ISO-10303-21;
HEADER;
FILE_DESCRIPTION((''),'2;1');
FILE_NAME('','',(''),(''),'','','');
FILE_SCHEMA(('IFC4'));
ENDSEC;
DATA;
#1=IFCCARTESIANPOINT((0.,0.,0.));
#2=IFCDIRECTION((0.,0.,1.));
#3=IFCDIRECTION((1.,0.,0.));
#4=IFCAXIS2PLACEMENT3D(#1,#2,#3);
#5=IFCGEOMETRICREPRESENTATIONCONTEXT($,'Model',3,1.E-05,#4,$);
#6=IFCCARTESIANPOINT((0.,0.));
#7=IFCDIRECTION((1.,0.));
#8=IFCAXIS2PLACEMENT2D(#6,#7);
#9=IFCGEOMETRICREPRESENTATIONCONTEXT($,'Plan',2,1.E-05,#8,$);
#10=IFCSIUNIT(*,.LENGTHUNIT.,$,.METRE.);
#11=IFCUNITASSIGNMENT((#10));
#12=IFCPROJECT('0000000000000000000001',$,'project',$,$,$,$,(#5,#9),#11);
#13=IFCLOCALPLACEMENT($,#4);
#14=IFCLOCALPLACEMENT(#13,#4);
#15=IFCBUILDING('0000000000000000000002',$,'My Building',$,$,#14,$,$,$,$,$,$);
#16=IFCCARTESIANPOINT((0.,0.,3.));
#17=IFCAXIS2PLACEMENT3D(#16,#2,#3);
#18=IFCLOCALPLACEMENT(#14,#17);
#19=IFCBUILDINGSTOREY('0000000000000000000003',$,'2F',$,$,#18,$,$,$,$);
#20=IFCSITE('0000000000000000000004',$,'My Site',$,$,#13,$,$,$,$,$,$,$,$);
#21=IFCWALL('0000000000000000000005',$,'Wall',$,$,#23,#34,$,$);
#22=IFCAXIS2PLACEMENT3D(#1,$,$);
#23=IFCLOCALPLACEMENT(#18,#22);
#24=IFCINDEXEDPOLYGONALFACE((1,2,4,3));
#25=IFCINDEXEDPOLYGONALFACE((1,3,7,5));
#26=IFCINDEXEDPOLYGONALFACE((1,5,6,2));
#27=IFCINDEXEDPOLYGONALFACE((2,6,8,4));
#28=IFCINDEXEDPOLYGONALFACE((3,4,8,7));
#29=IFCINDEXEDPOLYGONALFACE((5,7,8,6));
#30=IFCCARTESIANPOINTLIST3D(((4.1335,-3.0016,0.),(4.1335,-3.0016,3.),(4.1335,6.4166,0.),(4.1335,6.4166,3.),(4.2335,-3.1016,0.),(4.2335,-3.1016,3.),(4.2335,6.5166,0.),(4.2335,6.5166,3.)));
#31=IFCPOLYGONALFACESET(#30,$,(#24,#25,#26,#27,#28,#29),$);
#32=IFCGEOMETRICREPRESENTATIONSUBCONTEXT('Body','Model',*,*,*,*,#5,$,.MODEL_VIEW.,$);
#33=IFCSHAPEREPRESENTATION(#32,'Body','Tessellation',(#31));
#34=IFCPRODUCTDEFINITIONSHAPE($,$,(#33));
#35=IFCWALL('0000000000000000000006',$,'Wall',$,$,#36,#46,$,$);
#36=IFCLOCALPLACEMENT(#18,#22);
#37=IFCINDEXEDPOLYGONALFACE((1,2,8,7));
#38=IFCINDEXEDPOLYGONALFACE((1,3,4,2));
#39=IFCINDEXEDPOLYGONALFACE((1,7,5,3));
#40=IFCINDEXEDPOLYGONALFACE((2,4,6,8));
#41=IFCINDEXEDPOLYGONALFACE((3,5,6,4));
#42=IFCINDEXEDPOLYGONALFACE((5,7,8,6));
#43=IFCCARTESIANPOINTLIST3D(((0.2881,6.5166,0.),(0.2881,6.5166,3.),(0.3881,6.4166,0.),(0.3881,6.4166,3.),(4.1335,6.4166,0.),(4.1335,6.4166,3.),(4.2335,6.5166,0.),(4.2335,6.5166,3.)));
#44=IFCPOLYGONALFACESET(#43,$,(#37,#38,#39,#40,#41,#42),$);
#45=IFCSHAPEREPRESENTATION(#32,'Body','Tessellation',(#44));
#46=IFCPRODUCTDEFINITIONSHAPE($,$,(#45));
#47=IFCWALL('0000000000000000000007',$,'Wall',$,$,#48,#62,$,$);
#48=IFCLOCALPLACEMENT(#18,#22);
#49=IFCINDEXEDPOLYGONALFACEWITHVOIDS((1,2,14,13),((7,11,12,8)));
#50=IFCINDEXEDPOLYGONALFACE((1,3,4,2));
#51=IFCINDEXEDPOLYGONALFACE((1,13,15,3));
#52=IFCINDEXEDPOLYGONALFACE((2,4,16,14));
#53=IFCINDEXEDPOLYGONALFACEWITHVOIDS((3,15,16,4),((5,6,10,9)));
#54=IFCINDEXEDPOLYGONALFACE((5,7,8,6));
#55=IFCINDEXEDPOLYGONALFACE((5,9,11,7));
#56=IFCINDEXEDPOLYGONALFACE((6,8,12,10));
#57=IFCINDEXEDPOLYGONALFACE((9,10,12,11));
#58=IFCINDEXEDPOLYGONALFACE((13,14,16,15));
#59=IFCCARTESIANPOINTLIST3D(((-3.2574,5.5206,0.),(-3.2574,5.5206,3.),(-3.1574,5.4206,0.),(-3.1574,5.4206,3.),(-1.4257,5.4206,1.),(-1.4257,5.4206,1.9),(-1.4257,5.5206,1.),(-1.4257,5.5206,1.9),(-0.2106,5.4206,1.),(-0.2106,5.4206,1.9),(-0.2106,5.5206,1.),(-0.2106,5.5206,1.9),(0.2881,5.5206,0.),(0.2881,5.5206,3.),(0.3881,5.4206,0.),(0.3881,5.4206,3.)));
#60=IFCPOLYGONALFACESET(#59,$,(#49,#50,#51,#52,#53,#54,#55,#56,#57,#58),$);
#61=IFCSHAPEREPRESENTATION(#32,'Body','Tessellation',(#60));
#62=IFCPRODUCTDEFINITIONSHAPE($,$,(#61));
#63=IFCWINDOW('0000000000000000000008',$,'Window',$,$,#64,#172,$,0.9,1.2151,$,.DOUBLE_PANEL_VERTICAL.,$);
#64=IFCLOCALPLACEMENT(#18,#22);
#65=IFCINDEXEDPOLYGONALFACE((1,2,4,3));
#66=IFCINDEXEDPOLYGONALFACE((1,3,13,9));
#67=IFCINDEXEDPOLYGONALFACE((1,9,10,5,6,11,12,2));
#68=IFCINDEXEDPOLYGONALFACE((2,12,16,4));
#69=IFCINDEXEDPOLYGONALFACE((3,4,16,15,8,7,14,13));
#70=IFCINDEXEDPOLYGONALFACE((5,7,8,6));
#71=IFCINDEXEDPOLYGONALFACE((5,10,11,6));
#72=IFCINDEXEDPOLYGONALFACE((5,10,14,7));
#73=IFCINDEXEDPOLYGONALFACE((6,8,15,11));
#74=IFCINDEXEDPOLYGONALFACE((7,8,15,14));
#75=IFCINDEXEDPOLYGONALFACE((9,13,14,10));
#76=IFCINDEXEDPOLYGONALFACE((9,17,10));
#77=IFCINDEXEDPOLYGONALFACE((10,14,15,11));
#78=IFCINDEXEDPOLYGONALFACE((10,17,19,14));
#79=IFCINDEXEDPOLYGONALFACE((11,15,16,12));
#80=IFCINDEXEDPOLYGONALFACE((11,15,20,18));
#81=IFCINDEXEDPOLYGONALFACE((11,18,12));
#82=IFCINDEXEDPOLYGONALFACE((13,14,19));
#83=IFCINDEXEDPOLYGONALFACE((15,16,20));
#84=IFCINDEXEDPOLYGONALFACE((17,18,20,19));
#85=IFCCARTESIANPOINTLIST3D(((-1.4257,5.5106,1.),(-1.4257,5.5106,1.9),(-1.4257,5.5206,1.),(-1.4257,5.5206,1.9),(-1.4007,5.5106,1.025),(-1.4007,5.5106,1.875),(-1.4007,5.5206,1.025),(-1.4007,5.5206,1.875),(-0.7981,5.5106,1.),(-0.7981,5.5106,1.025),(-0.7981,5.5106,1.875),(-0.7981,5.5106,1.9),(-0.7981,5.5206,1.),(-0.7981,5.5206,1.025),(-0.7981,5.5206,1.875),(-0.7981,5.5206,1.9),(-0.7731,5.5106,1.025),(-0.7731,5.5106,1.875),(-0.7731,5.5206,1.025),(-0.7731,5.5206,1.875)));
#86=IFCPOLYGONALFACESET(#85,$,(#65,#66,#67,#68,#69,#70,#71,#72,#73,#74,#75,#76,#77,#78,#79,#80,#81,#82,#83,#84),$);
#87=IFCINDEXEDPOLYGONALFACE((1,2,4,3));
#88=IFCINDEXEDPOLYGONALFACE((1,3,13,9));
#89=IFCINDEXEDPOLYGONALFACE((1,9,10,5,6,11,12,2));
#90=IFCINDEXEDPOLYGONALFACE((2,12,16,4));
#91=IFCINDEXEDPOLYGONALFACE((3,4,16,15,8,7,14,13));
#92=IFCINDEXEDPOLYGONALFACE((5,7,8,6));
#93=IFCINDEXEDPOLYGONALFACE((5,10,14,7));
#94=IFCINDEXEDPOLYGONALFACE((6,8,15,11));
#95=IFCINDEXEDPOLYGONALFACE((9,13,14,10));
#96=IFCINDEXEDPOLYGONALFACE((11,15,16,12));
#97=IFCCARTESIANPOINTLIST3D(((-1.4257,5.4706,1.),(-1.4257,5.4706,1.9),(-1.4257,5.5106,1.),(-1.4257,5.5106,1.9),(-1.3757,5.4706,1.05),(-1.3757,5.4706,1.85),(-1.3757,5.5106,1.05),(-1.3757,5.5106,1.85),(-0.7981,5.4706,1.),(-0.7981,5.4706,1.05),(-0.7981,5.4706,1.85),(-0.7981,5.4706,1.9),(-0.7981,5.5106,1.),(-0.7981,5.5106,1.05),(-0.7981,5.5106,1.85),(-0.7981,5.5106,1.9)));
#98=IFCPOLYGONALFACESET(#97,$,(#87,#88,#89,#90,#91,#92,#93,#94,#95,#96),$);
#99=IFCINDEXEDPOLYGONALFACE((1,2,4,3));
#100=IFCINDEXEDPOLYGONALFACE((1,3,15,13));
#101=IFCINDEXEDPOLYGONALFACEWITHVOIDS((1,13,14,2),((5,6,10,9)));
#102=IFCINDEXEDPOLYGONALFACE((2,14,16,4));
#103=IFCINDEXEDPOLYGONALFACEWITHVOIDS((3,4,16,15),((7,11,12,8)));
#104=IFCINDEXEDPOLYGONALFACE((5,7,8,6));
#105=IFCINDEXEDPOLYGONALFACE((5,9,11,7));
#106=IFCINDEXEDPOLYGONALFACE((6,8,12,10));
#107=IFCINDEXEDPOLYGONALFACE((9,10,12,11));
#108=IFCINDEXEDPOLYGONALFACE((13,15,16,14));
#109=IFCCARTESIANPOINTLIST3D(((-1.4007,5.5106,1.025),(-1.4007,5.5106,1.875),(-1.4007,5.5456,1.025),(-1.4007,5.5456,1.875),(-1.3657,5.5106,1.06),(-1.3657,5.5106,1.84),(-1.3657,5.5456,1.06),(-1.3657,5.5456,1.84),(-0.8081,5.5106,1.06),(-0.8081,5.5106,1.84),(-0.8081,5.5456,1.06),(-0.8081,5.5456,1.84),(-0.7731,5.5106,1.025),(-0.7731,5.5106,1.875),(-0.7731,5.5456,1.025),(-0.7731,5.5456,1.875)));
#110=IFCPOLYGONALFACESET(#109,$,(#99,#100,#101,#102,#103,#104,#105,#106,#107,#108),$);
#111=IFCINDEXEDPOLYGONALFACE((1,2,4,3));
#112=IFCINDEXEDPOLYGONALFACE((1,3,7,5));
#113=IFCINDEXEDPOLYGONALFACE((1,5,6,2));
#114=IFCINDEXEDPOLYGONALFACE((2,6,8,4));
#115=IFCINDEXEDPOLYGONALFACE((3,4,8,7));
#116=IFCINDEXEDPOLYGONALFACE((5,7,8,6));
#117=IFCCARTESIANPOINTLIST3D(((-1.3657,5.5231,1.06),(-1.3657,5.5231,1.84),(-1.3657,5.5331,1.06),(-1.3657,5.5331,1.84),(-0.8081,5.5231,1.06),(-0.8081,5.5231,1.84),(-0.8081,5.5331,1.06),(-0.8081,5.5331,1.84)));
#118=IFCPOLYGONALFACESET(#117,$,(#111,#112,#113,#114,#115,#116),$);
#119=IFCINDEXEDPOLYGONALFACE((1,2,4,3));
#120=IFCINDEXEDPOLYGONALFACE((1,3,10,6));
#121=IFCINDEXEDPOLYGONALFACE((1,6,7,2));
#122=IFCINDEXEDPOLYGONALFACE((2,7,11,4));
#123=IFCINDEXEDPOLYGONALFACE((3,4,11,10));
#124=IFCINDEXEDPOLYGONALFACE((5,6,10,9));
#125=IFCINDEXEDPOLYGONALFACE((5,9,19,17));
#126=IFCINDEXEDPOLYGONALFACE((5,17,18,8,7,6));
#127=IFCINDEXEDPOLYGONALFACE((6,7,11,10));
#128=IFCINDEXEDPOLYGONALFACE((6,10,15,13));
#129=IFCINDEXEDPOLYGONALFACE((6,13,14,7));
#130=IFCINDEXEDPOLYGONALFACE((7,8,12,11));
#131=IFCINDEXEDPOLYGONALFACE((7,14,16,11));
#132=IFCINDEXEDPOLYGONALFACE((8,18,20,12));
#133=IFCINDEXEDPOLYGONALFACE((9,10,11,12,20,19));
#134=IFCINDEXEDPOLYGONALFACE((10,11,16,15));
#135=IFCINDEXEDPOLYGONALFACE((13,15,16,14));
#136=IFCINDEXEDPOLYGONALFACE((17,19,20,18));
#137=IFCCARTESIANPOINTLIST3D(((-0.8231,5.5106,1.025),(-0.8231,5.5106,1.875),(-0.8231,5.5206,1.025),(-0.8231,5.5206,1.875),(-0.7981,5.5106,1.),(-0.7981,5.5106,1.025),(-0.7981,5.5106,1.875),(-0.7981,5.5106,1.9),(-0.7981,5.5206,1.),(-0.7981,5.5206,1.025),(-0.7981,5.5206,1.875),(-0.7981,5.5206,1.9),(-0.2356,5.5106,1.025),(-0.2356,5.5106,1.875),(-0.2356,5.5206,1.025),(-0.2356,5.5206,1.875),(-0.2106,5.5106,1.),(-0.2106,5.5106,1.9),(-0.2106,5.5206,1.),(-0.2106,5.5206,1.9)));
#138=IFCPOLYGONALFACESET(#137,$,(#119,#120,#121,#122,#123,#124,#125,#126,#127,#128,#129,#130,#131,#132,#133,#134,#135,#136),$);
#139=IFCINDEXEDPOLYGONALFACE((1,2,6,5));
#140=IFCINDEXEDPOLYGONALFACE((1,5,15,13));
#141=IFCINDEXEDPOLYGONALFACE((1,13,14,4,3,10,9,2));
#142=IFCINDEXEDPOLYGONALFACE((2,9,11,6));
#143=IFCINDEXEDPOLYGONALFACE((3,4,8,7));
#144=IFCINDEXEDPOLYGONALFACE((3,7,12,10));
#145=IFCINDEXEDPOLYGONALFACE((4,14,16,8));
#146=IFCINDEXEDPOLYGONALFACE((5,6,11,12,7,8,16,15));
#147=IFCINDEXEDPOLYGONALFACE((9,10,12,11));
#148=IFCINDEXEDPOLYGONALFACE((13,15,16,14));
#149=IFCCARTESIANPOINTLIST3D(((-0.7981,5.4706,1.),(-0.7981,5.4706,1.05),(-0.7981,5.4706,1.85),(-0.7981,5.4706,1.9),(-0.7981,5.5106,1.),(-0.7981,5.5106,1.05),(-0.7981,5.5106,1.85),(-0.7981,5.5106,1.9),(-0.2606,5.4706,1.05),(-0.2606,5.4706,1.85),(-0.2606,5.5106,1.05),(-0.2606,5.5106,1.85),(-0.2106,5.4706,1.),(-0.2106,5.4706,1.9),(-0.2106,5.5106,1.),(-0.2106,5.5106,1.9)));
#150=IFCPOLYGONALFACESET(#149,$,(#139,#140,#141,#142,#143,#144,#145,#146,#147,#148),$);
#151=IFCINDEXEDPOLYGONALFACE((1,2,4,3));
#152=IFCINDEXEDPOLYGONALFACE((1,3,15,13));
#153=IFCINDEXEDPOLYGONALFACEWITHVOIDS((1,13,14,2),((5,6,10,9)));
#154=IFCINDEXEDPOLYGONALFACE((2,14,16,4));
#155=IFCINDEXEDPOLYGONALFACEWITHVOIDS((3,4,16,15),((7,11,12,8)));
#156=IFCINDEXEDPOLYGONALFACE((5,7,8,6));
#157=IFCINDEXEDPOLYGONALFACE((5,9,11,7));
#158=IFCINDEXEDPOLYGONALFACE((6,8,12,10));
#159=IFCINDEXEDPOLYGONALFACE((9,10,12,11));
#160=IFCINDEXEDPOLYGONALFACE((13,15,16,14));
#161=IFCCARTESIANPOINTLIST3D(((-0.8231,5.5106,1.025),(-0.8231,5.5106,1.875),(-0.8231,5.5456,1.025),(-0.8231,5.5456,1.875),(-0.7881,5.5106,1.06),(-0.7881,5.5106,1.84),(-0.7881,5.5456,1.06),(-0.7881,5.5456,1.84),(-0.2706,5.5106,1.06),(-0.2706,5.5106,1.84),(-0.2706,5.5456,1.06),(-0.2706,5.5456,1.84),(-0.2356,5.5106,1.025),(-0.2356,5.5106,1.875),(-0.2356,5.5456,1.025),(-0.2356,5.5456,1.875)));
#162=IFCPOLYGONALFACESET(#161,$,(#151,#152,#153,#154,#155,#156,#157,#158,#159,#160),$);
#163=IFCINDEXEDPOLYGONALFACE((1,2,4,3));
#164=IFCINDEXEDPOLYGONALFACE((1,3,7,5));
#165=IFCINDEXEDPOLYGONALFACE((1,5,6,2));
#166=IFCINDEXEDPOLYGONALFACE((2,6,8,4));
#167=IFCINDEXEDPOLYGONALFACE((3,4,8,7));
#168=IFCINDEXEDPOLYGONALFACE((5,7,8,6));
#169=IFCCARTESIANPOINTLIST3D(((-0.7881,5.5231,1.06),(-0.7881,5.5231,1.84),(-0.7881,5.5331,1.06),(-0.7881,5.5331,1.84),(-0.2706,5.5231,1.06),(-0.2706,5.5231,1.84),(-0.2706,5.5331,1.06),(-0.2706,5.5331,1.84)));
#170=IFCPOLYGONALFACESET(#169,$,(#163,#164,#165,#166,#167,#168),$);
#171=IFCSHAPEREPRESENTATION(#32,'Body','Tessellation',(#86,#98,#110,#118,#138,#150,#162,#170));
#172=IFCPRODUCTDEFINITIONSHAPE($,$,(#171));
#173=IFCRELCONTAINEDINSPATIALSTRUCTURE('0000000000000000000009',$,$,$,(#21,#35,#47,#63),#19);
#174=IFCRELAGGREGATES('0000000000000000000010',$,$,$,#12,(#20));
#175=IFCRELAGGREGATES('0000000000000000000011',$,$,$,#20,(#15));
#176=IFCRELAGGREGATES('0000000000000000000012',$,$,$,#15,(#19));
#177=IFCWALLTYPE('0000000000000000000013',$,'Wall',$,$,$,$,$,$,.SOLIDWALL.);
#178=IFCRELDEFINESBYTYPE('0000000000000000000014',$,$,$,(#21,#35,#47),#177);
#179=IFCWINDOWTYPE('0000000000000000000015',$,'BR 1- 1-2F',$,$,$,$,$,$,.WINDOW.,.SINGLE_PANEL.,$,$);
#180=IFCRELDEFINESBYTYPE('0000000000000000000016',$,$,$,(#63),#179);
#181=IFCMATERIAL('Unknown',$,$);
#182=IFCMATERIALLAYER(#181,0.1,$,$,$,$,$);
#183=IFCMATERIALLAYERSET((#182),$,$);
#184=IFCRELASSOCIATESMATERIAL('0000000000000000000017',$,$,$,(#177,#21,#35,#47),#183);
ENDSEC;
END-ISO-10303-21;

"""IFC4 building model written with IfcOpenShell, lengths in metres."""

from ifc_helpers import new_model, entity, si_unit, frame, origin_with_axes, origin_2d_with_axis, place, context, subcontext, project, spatial, line, indexed_curve, outline, extrude, shape, source, transform, mapped, material, layer, layer_set, layer_usage, type_object, type_shapes, element, fill, save


model = new_model("IFC4")

# Units and contexts
model_context = context("Model", 3, precision=1e-05, world=origin_with_axes())
plan_context = context("Plan", 2, precision=1e-05, world=origin_2d_with_axis())
body_context_1 = subcontext(model_context, "Body", "Model", "MODEL_VIEW")
body_context_2 = subcontext(plan_context, "Body", "Plan", "PLAN_VIEW")
ifc_project = project(units=[si_unit("LENGTHUNIT", "METRE")], contexts=[model_context, plan_context])

# Site, building, storey
site_placement = place(None, origin_with_axes())
site = spatial("IfcSite", under=ifc_project, at=site_placement, Name="My Site")
building_placement = place(site_placement, origin_with_axes())
building = spatial("IfcBuilding", under=site, at=building_placement, Name="My Building")
storey_placement = place(building_placement, frame((0.0, 0.0, 3.0), z_axis=(0.0, 0.0, 1.0), x_axis=(1.0, 0.0, 0.0)))
storey = spatial("IfcBuildingStorey", under=building, at=storey_placement, Name="2F")

# Shared definitions
ifc_material = material(Name="Unknown")

# Walls
ifc_layer_1 = layer(ifc_material, 0.1)
ifc_layer_set_1 = layer_set([ifc_layer_1])
ifc_layer_usage_1 = layer_usage(ifc_layer_set_1, "AXIS2", "POSITIVE", 0.0)
wall_type = type_object("IfcWallType", Name="Wall", PredefinedType="SOLIDWALL", material=ifc_layer_set_1)
wall_1_placement = place(storey_placement, frame((4.2335, -3.1016, 0.0), z_axis=(0.0, 0.0, 1.0), x_axis=(0.0, 1.0, 0.0)))
element("IfcWall", 1, at=wall_1_placement, inside=storey, type_object=wall_type, material=ifc_layer_usage_1, Name="Wall", context=body_context_1, shape_type="SweptSolid", body=[
    extrude(outline(indexed_curve([(0.0, 0.0), (0.1, 0.1), (9.5182, 0.1), (9.6182, 0.0)], segments=[line(1, 2, 3, 4, 1)])), origin_with_axes(), (0.0, 0.0, 1.0), 3.0),
])
ifc_layer_usage_2 = layer_usage(ifc_layer_set_1, "AXIS2", "POSITIVE", 0.0)
wall_2_placement = place(storey_placement, frame((4.2335, 6.5166, 0.0), z_axis=(0.0, 0.0, 1.0), x_axis=(-1.0, 0.0, 0.0)))
element("IfcWall", 2, at=wall_2_placement, inside=storey, type_object=wall_type, material=ifc_layer_usage_2, Name="Wall", context=body_context_1, shape_type="SweptSolid", body=[
    extrude(outline(indexed_curve([(0.0, 0.0), (0.1, 0.1), (3.8454, 0.1), (3.9454, 0.0)], segments=[line(1, 2, 3, 4, 1)])), origin_with_axes(), (0.0, 0.0, 1.0), 3.0),
])

# Wall, opening, window
ifc_layer_usage_3 = layer_usage(ifc_layer_set_1, "AXIS2", "POSITIVE", 0.0)
wall_3_placement = place(storey_placement, frame((0.3881, 5.5206, 0.0), z_axis=(0.0, 0.0, 1.0), x_axis=(-1.0, 0.0, 0.0)))
wall_3 = element("IfcWall", 3, at=wall_3_placement, inside=storey, type_object=wall_type, material=ifc_layer_usage_3, Name="Wall", context=body_context_1, shape_type="SweptSolid", body=[
    extrude(outline(indexed_curve([(0.1, 0.0), (0.0, 0.1), (3.5455, 0.1), (3.6455, 0.0)], segments=[line(1, 2, 3, 4, 1)])), origin_with_axes(), (0.0, 0.0, 1.0), 3.0),
])
shared_shape_1 = source(origin_with_axes(), body_context_1, "Body", "SweptSolid", [
    extrude(outline(indexed_curve([(0.0, 0.0), (1.2151, 0.0), (1.2151, 0.9), (0.0, 0.9)], segments=[line(1, 2, 3, 4, 1)])), frame((0.0, -0.6, 0.0), z_axis=(0.0, -1.0, 0.0), x_axis=(1.0, 0.0, 0.0)), (0.0, 0.0, -1.0), 1.2),
])
opening_1_placement = place(wall_3_placement, frame((1.8138, 0.1, 1.0), z_axis=(0.0, 0.0, 1.0), x_axis=(-1.0, 0.0, 0.0)))
opening_1 = element("IfcOpeningElement", 4, at=opening_1_placement, cuts=wall_3, PredefinedType="OPENING", context=body_context_1, shape_type="MappedRepresentation", body=[
    mapped(shared_shape_1, transform((0.0, 0.0, 0.0), x_axis=(1.0, 0.0, 0.0), y_axis=(0.0, 1.0, 0.0), z_axis=(0.0, 0.0, 1.0), scale=1.0)),
])
window_type_1 = type_object("IfcWindowType", Name="BR 1- 1-2F", PartitioningType="SINGLE_PANEL", PredefinedType="WINDOW")
shared_shape_2 = source(origin_with_axes(), body_context_1, "Body", "SweptSolid", [
    extrude(outline(indexed_curve([(0.0, 0.0), (0.6275, 0.0), (0.6275, 0.9), (0.0, 0.9)], segments=[line(1, 2, 3, 4, 1)]), holes=[indexed_curve([(0.025, 0.025), (0.6525, 0.025), (0.6525, 0.875), (0.025, 0.875)], segments=[line(1, 2, 3, 4, 1)])]), frame((0.0, 0.09, 0.0), z_axis=(0.0, -1.0, 0.0), x_axis=(1.0, 0.0, 0.0)), (0.0, 0.0, -1.0), 0.01),
    extrude(outline(indexed_curve([(0.6275, 0.0), (0.0, 0.0), (0.0, 0.9), (0.6275, 0.9), (0.6275, 0.85), (0.05, 0.85), (0.05, 0.05), (0.6275, 0.05)], segments=[line(1, 2, 3, 4, 5, 6, 7, 8, 1)])), frame((0.0, 0.05, 0.0), z_axis=(0.0, -1.0, 0.0), x_axis=(1.0, 0.0, 0.0)), (0.0, 0.0, -1.0), 0.04),
    extrude(outline(indexed_curve([(0.0, 0.0), (0.6275, 0.0), (0.6275, 0.85), (0.0, 0.85)], segments=[line(1, 2, 3, 4, 1)]), holes=[indexed_curve([(0.035, 0.035), (0.5925, 0.035), (0.5925, 0.815), (0.035, 0.815)], segments=[line(1, 2, 3, 4, 1)])]), frame((0.025, 0.09, 0.025), z_axis=(0.0, -1.0, 0.0), x_axis=(1.0, 0.0, 0.0)), (0.0, 0.0, -1.0), 0.035),
    extrude(outline(indexed_curve([(0.035, 0.035), (0.5925, 0.035), (0.5925, 0.815), (0.035, 0.815)], segments=[line(1, 2, 3, 4, 1)])), frame((0.025, 0.1025, 0.025), z_axis=(0.0, -1.0, 0.0), x_axis=(1.0, 0.0, 0.0)), (0.0, 0.0, -1.0), 0.01),
    extrude(outline(indexed_curve([(0.0, 0.0), (0.5875, 0.0), (0.5875, 0.9), (0.0, 0.9)], segments=[line(1, 2, 3, 4, 1)]), holes=[indexed_curve([(-0.025, 0.025), (0.5625, 0.025), (0.5625, 0.875), (-0.025, 0.875)], segments=[line(1, 2, 3, 4, 1)])]), frame((0.6275, 0.09, 0.0), z_axis=(0.0, -1.0, 0.0), x_axis=(1.0, 0.0, 0.0)), (0.0, 0.0, -1.0), 0.01),
    extrude(outline(indexed_curve([(0.0, 0.9), (0.5875, 0.9), (0.5875, 0.0), (0.0, 0.0), (0.0, 0.05), (0.5375, 0.05), (0.5375, 0.85), (0.0, 0.85)], segments=[line(1, 2, 3, 4, 5, 6, 7, 8, 1)])), frame((0.6275, 0.05, 0.0), z_axis=(0.0, -1.0, 0.0), x_axis=(1.0, 0.0, 0.0)), (0.0, 0.0, -1.0), 0.04),
    extrude(outline(indexed_curve([(0.0, 0.0), (0.5875, 0.0), (0.5875, 0.85), (0.0, 0.85)], segments=[line(1, 2, 3, 4, 1)]), holes=[indexed_curve([(0.035, 0.035), (0.5525, 0.035), (0.5525, 0.815), (0.035, 0.815)], segments=[line(1, 2, 3, 4, 1)])]), frame((0.6025, 0.09, 0.025), z_axis=(0.0, -1.0, 0.0), x_axis=(1.0, 0.0, 0.0)), (0.0, 0.0, -1.0), 0.035),
    extrude(outline(indexed_curve([(0.035, 0.035), (0.5525, 0.035), (0.5525, 0.815), (0.035, 0.815)], segments=[line(1, 2, 3, 4, 1)])), frame((0.6025, 0.1025, 0.025), z_axis=(0.0, -1.0, 0.0), x_axis=(1.0, 0.0, 0.0)), (0.0, 0.0, -1.0), 0.01),
])
shared_shape_3 = source(origin_with_axes(), body_context_2, "Body", "Curve2D", [
    entity("IfcIndexedPolyCurve", entity("IfcCartesianPointList2D", [[0.05, 0.05], [0.6275, 0.05]])),
    entity("IfcIndexedPolyCurve", entity("IfcCartesianPointList2D", [[0.0, 0.1], [0.025, 0.1], [0.025, 0.09], [0.05, 0.09], [0.05, 0.05], [0.0, 0.05]]), [entity("IfcLineIndex", [1, 2, 3, 4, 5, 6, 1])]),
    entity("IfcIndexedPolyCurve", entity("IfcCartesianPointList2D", [[0.6275, 0.1], [0.6525, 0.1], [0.6525, 0.09], [0.6275, 0.09], [0.6275, 0.05], [0.6275, 0.05]])),
    entity("IfcIndexedPolyCurve", entity("IfcCartesianPointList2D", [[0.025, 0.09], [0.06, 0.09], [0.06, 0.125], [0.025, 0.125]]), [entity("IfcLineIndex", [1, 2, 3, 4, 1])]),
    entity("IfcIndexedPolyCurve", entity("IfcCartesianPointList2D", [[0.6525, 0.09], [0.6175, 0.09], [0.6175, 0.125], [0.6525, 0.125]]), [entity("IfcLineIndex", [1, 2, 3, 4, 1])]),
    entity("IfcIndexedPolyCurve", entity("IfcCartesianPointList2D", [[0.06, 0.09], [0.6175, 0.09]])),
    entity("IfcIndexedPolyCurve", entity("IfcCartesianPointList2D", [[0.06, 0.125], [0.6175, 0.125]])),
    entity("IfcIndexedPolyCurve", entity("IfcCartesianPointList2D", [[0.06, 0.1075], [0.6175, 0.1075]])),
    entity("IfcIndexedPolyCurve", entity("IfcCartesianPointList2D", [[0.6275, 0.05], [1.1651, 0.05]])),
    entity("IfcIndexedPolyCurve", entity("IfcCartesianPointList2D", [[0.6275, 0.1], [0.6025, 0.1], [0.6025, 0.09], [0.6275, 0.09], [0.6275, 0.05], [0.6275, 0.05]])),
    entity("IfcIndexedPolyCurve", entity("IfcCartesianPointList2D", [[1.2151, 0.1], [1.1901, 0.1], [1.1901, 0.09], [1.1651, 0.09], [1.1651, 0.05], [1.2151, 0.05]]), [entity("IfcLineIndex", [1, 2, 3, 4, 5, 6, 1])]),
    entity("IfcIndexedPolyCurve", entity("IfcCartesianPointList2D", [[0.6025, 0.09], [0.6375, 0.09], [0.6375, 0.125], [0.6025, 0.125]]), [entity("IfcLineIndex", [1, 2, 3, 4, 1])]),
    entity("IfcIndexedPolyCurve", entity("IfcCartesianPointList2D", [[1.1901, 0.09], [1.1551, 0.09], [1.1551, 0.125], [1.1901, 0.125]]), [entity("IfcLineIndex", [1, 2, 3, 4, 1])]),
    entity("IfcIndexedPolyCurve", entity("IfcCartesianPointList2D", [[0.6375, 0.09], [1.1551, 0.09]])),
    entity("IfcIndexedPolyCurve", entity("IfcCartesianPointList2D", [[0.6375, 0.125], [1.1551, 0.125]])),
    entity("IfcIndexedPolyCurve", entity("IfcCartesianPointList2D", [[0.6375, 0.1075], [1.1551, 0.1075]])),
])
type_shapes(window_type_1, [shared_shape_2, shared_shape_3])
window_1_placement = place(opening_1_placement, frame((0.0, 0.0, 0.0), z_axis=(0.0, 0.0, 1.0), x_axis=(1.0, 0.0, 0.0)))
window_1 = element("IfcWindow", 5, at=window_1_placement, inside=storey, type_object=window_type_1, Name="Window", OverallHeight=0.9, OverallWidth=1.2151, PartitioningType="DOUBLE_PANEL_VERTICAL", shapes=[
    shape(body_context_1, "Body", "MappedRepresentation", [mapped(shared_shape_2, transform((0.0, 0.0, 0.0), x_axis=(1.0, 0.0, 0.0), y_axis=(0.0, 1.0, 0.0), z_axis=(0.0, 0.0, 1.0), scale=1.0))]),
    shape(body_context_2, "Body", "MappedRepresentation", [mapped(shared_shape_3, transform((0.0, 0.0, 0.0), x_axis=(1.0, 0.0, 0.0), y_axis=(0.0, 1.0, 0.0), z_axis=(0.0, 0.0, 1.0), scale=1.0))]),
])
fill(opening_1, window_1)

save(model, "model.ifc")
